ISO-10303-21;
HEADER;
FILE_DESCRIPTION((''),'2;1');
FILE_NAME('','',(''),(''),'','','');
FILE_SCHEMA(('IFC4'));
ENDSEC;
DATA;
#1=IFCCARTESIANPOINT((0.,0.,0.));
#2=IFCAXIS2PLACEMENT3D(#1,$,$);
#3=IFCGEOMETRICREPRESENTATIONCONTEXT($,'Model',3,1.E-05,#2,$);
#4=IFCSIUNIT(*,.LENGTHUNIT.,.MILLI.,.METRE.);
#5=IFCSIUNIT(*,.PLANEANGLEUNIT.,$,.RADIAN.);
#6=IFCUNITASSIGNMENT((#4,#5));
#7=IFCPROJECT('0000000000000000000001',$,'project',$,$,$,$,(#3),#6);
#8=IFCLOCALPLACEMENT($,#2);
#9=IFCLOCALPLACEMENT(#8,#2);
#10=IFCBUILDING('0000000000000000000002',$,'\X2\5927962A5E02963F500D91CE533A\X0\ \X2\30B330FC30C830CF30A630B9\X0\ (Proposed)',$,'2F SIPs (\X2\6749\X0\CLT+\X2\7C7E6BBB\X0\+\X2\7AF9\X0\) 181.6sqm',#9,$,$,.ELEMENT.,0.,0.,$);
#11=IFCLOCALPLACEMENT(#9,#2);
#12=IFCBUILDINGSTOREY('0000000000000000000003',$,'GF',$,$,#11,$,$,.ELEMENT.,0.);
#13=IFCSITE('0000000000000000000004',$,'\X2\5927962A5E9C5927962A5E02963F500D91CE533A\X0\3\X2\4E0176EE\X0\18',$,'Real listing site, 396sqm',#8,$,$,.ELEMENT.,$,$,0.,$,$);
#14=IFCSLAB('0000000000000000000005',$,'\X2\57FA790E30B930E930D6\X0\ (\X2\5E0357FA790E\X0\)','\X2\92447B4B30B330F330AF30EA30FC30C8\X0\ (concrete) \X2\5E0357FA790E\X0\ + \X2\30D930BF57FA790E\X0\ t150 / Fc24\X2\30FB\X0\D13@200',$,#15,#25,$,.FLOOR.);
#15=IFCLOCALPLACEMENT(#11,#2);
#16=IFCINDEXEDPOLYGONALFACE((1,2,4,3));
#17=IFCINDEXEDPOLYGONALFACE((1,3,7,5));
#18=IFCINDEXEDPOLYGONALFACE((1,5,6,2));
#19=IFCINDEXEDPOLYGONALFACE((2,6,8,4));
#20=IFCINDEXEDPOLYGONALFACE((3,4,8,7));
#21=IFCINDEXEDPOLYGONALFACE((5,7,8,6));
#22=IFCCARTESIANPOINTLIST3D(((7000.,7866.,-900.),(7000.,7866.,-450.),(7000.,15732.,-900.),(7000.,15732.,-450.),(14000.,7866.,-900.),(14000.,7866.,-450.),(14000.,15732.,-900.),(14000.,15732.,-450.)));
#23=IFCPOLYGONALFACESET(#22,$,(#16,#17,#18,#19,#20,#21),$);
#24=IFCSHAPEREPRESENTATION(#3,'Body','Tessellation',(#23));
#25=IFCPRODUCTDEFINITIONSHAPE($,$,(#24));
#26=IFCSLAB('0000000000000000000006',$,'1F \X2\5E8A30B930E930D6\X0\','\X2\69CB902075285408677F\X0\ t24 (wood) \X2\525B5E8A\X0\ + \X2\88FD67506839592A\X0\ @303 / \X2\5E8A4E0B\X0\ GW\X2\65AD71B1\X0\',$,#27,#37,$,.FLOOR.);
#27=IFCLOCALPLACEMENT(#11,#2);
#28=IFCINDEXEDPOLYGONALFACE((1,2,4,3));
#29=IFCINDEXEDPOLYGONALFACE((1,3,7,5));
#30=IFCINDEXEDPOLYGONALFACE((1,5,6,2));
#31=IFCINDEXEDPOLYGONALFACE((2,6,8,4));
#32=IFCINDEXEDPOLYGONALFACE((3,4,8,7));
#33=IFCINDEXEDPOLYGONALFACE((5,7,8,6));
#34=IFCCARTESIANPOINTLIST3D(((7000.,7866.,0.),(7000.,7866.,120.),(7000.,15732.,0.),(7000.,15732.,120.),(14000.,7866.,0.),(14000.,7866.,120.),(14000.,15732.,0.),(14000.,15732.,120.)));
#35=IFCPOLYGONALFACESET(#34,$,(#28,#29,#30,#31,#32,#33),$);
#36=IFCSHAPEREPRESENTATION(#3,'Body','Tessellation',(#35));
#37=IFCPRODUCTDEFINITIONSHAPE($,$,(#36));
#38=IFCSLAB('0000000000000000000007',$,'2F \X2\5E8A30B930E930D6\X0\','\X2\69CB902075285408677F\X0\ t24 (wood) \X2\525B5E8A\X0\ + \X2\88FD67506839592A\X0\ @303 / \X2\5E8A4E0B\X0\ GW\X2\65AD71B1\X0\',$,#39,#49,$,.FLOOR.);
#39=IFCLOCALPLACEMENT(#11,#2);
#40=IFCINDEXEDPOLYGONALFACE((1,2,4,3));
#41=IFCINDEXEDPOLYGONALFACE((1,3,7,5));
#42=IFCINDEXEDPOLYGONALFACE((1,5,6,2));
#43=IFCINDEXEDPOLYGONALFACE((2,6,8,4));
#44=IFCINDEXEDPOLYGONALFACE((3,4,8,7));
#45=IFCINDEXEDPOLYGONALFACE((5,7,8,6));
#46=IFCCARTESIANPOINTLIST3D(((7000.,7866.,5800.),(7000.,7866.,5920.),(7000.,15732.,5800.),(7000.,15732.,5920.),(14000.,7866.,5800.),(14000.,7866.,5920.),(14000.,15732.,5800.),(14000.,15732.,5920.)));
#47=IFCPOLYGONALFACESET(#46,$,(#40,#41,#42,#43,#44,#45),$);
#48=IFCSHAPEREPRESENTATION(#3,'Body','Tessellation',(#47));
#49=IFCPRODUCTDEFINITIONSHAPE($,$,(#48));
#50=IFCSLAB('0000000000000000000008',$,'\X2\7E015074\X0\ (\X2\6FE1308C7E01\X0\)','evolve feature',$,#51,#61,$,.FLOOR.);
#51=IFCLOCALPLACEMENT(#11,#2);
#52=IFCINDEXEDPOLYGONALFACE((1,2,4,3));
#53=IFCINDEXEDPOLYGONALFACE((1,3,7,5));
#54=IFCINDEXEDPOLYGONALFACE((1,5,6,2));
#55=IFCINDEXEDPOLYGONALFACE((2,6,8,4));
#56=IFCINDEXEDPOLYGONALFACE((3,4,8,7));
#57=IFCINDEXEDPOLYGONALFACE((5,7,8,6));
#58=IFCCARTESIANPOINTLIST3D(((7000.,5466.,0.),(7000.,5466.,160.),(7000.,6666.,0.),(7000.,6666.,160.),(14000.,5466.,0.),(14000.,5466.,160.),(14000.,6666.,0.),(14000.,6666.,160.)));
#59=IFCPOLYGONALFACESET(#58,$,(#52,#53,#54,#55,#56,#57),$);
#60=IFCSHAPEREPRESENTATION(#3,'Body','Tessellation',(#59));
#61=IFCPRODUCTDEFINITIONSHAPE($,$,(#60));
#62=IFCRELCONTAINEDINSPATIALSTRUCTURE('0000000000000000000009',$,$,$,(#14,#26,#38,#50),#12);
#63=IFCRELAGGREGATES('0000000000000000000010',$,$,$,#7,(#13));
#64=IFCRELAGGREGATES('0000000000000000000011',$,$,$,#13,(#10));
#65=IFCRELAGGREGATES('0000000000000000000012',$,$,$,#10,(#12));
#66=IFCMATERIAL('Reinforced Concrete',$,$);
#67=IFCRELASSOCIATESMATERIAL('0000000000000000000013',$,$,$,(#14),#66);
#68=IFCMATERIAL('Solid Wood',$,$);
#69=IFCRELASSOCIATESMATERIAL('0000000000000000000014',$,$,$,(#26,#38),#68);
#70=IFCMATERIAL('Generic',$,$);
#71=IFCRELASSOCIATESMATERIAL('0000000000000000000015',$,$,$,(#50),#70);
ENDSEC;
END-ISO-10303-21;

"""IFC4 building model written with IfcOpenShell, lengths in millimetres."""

from ifc_helpers import new_model, si_unit, frame, frame_2d, origin, place, context, project, spatial, rectangle, extrude, material, element, save


model = new_model("IFC4")

# Units and contexts
model_context = context("Model", 3, precision=1e-05, world=origin())
ifc_project = project(units=[si_unit("LENGTHUNIT", "METRE", prefix="MILLI"), si_unit("PLANEANGLEUNIT", "RADIAN")], contexts=[model_context])

# Site, building, storey
site_placement = place(None, origin())
site = spatial("IfcSite", under=ifc_project, at=site_placement, Name="大阪府大阪市阿倍野区3丁目18", ObjectType="Real listing site, 396sqm", CompositionType="ELEMENT", RefElevation=0.0)
building_placement = place(site_placement, origin())
building = spatial("IfcBuilding", under=site, at=building_placement, Name="大阪市阿倍野区 コートハウス (Proposed)", ObjectType="2F SIPs (杉CLT+籾殻+竹) 181.6sqm", CompositionType="ELEMENT", ElevationOfRefHeight=0.0, ElevationOfTerrain=0.0)
storey_placement = place(building_placement, origin())
storey = spatial("IfcBuildingStorey", under=building, at=storey_placement, Name="GF", CompositionType="ELEMENT", Elevation=0.0)

# Slabs
ifc_material_1 = material(Name="Reinforced Concrete")
slab_1_placement = place(storey_placement, frame((3500.0, 3933.0, -450.0)))
element("IfcSlab", 1, at=slab_1_placement, inside=storey, material=ifc_material_1, Name="基礎スラブ (布基礎)", Description="鉄筋コンクリート (concrete) 布基礎 + ベタ基礎 t150 / Fc24・D13@200", PredefinedType="FLOOR", context=model_context, shape_type="SweptSolid", body=[
    extrude(rectangle(XDim=7000.0, YDim=7866.0, at=frame_2d((3500.0, 3933.0))), frame((3500.0, 3933.0, -450.0)), (0.0, 0.0, 1.0), 450.0),
])
ifc_material_2 = material(Name="Solid Wood")
slab_2_placement = place(storey_placement, frame((3500.0, 3933.0, 0.0)))
element("IfcSlab", 2, at=slab_2_placement, inside=storey, material=ifc_material_2, Name="1F 床スラブ", Description="構造用合板 t24 (wood) 剛床 + 製材根太 @303 / 床下 GW断熱", PredefinedType="FLOOR", context=model_context, shape_type="SweptSolid", body=[
    extrude(rectangle(XDim=7000.0, YDim=7866.0, at=frame_2d((3500.0, 3933.0))), frame((3500.0, 3933.0, 0.0)), (0.0, 0.0, 1.0), 120.0),
])
slab_3_placement = place(storey_placement, frame((3500.0, 3933.0, 2900.0)))
element("IfcSlab", 3, at=slab_3_placement, inside=storey, material=ifc_material_2, Name="2F 床スラブ", Description="構造用合板 t24 (wood) 剛床 + 製材根太 @303 / 床下 GW断熱", PredefinedType="FLOOR", context=model_context, shape_type="SweptSolid", body=[
    extrude(rectangle(XDim=7000.0, YDim=7866.0, at=frame_2d((3500.0, 3933.0))), frame((3500.0, 3933.0, 2900.0)), (0.0, 0.0, 1.0), 120.0),
])
ifc_material_3 = material(Name="Generic")
slab_4_placement = place(storey_placement, frame((3500.0, 2733.0, 0.0)))
element("IfcSlab", 4, at=slab_4_placement, inside=storey, material=ifc_material_3, Name="縁側 (濡れ縁)", Description="evolve feature", PredefinedType="FLOOR", context=model_context, shape_type="SweptSolid", body=[
    extrude(rectangle(XDim=7000.0, YDim=1200.0, at=frame_2d((3500.0, 600.0))), frame((3500.0, 2733.0, 0.0)), (0.0, 0.0, 1.0), 160.0),
])

save(model, "model.ifc")
